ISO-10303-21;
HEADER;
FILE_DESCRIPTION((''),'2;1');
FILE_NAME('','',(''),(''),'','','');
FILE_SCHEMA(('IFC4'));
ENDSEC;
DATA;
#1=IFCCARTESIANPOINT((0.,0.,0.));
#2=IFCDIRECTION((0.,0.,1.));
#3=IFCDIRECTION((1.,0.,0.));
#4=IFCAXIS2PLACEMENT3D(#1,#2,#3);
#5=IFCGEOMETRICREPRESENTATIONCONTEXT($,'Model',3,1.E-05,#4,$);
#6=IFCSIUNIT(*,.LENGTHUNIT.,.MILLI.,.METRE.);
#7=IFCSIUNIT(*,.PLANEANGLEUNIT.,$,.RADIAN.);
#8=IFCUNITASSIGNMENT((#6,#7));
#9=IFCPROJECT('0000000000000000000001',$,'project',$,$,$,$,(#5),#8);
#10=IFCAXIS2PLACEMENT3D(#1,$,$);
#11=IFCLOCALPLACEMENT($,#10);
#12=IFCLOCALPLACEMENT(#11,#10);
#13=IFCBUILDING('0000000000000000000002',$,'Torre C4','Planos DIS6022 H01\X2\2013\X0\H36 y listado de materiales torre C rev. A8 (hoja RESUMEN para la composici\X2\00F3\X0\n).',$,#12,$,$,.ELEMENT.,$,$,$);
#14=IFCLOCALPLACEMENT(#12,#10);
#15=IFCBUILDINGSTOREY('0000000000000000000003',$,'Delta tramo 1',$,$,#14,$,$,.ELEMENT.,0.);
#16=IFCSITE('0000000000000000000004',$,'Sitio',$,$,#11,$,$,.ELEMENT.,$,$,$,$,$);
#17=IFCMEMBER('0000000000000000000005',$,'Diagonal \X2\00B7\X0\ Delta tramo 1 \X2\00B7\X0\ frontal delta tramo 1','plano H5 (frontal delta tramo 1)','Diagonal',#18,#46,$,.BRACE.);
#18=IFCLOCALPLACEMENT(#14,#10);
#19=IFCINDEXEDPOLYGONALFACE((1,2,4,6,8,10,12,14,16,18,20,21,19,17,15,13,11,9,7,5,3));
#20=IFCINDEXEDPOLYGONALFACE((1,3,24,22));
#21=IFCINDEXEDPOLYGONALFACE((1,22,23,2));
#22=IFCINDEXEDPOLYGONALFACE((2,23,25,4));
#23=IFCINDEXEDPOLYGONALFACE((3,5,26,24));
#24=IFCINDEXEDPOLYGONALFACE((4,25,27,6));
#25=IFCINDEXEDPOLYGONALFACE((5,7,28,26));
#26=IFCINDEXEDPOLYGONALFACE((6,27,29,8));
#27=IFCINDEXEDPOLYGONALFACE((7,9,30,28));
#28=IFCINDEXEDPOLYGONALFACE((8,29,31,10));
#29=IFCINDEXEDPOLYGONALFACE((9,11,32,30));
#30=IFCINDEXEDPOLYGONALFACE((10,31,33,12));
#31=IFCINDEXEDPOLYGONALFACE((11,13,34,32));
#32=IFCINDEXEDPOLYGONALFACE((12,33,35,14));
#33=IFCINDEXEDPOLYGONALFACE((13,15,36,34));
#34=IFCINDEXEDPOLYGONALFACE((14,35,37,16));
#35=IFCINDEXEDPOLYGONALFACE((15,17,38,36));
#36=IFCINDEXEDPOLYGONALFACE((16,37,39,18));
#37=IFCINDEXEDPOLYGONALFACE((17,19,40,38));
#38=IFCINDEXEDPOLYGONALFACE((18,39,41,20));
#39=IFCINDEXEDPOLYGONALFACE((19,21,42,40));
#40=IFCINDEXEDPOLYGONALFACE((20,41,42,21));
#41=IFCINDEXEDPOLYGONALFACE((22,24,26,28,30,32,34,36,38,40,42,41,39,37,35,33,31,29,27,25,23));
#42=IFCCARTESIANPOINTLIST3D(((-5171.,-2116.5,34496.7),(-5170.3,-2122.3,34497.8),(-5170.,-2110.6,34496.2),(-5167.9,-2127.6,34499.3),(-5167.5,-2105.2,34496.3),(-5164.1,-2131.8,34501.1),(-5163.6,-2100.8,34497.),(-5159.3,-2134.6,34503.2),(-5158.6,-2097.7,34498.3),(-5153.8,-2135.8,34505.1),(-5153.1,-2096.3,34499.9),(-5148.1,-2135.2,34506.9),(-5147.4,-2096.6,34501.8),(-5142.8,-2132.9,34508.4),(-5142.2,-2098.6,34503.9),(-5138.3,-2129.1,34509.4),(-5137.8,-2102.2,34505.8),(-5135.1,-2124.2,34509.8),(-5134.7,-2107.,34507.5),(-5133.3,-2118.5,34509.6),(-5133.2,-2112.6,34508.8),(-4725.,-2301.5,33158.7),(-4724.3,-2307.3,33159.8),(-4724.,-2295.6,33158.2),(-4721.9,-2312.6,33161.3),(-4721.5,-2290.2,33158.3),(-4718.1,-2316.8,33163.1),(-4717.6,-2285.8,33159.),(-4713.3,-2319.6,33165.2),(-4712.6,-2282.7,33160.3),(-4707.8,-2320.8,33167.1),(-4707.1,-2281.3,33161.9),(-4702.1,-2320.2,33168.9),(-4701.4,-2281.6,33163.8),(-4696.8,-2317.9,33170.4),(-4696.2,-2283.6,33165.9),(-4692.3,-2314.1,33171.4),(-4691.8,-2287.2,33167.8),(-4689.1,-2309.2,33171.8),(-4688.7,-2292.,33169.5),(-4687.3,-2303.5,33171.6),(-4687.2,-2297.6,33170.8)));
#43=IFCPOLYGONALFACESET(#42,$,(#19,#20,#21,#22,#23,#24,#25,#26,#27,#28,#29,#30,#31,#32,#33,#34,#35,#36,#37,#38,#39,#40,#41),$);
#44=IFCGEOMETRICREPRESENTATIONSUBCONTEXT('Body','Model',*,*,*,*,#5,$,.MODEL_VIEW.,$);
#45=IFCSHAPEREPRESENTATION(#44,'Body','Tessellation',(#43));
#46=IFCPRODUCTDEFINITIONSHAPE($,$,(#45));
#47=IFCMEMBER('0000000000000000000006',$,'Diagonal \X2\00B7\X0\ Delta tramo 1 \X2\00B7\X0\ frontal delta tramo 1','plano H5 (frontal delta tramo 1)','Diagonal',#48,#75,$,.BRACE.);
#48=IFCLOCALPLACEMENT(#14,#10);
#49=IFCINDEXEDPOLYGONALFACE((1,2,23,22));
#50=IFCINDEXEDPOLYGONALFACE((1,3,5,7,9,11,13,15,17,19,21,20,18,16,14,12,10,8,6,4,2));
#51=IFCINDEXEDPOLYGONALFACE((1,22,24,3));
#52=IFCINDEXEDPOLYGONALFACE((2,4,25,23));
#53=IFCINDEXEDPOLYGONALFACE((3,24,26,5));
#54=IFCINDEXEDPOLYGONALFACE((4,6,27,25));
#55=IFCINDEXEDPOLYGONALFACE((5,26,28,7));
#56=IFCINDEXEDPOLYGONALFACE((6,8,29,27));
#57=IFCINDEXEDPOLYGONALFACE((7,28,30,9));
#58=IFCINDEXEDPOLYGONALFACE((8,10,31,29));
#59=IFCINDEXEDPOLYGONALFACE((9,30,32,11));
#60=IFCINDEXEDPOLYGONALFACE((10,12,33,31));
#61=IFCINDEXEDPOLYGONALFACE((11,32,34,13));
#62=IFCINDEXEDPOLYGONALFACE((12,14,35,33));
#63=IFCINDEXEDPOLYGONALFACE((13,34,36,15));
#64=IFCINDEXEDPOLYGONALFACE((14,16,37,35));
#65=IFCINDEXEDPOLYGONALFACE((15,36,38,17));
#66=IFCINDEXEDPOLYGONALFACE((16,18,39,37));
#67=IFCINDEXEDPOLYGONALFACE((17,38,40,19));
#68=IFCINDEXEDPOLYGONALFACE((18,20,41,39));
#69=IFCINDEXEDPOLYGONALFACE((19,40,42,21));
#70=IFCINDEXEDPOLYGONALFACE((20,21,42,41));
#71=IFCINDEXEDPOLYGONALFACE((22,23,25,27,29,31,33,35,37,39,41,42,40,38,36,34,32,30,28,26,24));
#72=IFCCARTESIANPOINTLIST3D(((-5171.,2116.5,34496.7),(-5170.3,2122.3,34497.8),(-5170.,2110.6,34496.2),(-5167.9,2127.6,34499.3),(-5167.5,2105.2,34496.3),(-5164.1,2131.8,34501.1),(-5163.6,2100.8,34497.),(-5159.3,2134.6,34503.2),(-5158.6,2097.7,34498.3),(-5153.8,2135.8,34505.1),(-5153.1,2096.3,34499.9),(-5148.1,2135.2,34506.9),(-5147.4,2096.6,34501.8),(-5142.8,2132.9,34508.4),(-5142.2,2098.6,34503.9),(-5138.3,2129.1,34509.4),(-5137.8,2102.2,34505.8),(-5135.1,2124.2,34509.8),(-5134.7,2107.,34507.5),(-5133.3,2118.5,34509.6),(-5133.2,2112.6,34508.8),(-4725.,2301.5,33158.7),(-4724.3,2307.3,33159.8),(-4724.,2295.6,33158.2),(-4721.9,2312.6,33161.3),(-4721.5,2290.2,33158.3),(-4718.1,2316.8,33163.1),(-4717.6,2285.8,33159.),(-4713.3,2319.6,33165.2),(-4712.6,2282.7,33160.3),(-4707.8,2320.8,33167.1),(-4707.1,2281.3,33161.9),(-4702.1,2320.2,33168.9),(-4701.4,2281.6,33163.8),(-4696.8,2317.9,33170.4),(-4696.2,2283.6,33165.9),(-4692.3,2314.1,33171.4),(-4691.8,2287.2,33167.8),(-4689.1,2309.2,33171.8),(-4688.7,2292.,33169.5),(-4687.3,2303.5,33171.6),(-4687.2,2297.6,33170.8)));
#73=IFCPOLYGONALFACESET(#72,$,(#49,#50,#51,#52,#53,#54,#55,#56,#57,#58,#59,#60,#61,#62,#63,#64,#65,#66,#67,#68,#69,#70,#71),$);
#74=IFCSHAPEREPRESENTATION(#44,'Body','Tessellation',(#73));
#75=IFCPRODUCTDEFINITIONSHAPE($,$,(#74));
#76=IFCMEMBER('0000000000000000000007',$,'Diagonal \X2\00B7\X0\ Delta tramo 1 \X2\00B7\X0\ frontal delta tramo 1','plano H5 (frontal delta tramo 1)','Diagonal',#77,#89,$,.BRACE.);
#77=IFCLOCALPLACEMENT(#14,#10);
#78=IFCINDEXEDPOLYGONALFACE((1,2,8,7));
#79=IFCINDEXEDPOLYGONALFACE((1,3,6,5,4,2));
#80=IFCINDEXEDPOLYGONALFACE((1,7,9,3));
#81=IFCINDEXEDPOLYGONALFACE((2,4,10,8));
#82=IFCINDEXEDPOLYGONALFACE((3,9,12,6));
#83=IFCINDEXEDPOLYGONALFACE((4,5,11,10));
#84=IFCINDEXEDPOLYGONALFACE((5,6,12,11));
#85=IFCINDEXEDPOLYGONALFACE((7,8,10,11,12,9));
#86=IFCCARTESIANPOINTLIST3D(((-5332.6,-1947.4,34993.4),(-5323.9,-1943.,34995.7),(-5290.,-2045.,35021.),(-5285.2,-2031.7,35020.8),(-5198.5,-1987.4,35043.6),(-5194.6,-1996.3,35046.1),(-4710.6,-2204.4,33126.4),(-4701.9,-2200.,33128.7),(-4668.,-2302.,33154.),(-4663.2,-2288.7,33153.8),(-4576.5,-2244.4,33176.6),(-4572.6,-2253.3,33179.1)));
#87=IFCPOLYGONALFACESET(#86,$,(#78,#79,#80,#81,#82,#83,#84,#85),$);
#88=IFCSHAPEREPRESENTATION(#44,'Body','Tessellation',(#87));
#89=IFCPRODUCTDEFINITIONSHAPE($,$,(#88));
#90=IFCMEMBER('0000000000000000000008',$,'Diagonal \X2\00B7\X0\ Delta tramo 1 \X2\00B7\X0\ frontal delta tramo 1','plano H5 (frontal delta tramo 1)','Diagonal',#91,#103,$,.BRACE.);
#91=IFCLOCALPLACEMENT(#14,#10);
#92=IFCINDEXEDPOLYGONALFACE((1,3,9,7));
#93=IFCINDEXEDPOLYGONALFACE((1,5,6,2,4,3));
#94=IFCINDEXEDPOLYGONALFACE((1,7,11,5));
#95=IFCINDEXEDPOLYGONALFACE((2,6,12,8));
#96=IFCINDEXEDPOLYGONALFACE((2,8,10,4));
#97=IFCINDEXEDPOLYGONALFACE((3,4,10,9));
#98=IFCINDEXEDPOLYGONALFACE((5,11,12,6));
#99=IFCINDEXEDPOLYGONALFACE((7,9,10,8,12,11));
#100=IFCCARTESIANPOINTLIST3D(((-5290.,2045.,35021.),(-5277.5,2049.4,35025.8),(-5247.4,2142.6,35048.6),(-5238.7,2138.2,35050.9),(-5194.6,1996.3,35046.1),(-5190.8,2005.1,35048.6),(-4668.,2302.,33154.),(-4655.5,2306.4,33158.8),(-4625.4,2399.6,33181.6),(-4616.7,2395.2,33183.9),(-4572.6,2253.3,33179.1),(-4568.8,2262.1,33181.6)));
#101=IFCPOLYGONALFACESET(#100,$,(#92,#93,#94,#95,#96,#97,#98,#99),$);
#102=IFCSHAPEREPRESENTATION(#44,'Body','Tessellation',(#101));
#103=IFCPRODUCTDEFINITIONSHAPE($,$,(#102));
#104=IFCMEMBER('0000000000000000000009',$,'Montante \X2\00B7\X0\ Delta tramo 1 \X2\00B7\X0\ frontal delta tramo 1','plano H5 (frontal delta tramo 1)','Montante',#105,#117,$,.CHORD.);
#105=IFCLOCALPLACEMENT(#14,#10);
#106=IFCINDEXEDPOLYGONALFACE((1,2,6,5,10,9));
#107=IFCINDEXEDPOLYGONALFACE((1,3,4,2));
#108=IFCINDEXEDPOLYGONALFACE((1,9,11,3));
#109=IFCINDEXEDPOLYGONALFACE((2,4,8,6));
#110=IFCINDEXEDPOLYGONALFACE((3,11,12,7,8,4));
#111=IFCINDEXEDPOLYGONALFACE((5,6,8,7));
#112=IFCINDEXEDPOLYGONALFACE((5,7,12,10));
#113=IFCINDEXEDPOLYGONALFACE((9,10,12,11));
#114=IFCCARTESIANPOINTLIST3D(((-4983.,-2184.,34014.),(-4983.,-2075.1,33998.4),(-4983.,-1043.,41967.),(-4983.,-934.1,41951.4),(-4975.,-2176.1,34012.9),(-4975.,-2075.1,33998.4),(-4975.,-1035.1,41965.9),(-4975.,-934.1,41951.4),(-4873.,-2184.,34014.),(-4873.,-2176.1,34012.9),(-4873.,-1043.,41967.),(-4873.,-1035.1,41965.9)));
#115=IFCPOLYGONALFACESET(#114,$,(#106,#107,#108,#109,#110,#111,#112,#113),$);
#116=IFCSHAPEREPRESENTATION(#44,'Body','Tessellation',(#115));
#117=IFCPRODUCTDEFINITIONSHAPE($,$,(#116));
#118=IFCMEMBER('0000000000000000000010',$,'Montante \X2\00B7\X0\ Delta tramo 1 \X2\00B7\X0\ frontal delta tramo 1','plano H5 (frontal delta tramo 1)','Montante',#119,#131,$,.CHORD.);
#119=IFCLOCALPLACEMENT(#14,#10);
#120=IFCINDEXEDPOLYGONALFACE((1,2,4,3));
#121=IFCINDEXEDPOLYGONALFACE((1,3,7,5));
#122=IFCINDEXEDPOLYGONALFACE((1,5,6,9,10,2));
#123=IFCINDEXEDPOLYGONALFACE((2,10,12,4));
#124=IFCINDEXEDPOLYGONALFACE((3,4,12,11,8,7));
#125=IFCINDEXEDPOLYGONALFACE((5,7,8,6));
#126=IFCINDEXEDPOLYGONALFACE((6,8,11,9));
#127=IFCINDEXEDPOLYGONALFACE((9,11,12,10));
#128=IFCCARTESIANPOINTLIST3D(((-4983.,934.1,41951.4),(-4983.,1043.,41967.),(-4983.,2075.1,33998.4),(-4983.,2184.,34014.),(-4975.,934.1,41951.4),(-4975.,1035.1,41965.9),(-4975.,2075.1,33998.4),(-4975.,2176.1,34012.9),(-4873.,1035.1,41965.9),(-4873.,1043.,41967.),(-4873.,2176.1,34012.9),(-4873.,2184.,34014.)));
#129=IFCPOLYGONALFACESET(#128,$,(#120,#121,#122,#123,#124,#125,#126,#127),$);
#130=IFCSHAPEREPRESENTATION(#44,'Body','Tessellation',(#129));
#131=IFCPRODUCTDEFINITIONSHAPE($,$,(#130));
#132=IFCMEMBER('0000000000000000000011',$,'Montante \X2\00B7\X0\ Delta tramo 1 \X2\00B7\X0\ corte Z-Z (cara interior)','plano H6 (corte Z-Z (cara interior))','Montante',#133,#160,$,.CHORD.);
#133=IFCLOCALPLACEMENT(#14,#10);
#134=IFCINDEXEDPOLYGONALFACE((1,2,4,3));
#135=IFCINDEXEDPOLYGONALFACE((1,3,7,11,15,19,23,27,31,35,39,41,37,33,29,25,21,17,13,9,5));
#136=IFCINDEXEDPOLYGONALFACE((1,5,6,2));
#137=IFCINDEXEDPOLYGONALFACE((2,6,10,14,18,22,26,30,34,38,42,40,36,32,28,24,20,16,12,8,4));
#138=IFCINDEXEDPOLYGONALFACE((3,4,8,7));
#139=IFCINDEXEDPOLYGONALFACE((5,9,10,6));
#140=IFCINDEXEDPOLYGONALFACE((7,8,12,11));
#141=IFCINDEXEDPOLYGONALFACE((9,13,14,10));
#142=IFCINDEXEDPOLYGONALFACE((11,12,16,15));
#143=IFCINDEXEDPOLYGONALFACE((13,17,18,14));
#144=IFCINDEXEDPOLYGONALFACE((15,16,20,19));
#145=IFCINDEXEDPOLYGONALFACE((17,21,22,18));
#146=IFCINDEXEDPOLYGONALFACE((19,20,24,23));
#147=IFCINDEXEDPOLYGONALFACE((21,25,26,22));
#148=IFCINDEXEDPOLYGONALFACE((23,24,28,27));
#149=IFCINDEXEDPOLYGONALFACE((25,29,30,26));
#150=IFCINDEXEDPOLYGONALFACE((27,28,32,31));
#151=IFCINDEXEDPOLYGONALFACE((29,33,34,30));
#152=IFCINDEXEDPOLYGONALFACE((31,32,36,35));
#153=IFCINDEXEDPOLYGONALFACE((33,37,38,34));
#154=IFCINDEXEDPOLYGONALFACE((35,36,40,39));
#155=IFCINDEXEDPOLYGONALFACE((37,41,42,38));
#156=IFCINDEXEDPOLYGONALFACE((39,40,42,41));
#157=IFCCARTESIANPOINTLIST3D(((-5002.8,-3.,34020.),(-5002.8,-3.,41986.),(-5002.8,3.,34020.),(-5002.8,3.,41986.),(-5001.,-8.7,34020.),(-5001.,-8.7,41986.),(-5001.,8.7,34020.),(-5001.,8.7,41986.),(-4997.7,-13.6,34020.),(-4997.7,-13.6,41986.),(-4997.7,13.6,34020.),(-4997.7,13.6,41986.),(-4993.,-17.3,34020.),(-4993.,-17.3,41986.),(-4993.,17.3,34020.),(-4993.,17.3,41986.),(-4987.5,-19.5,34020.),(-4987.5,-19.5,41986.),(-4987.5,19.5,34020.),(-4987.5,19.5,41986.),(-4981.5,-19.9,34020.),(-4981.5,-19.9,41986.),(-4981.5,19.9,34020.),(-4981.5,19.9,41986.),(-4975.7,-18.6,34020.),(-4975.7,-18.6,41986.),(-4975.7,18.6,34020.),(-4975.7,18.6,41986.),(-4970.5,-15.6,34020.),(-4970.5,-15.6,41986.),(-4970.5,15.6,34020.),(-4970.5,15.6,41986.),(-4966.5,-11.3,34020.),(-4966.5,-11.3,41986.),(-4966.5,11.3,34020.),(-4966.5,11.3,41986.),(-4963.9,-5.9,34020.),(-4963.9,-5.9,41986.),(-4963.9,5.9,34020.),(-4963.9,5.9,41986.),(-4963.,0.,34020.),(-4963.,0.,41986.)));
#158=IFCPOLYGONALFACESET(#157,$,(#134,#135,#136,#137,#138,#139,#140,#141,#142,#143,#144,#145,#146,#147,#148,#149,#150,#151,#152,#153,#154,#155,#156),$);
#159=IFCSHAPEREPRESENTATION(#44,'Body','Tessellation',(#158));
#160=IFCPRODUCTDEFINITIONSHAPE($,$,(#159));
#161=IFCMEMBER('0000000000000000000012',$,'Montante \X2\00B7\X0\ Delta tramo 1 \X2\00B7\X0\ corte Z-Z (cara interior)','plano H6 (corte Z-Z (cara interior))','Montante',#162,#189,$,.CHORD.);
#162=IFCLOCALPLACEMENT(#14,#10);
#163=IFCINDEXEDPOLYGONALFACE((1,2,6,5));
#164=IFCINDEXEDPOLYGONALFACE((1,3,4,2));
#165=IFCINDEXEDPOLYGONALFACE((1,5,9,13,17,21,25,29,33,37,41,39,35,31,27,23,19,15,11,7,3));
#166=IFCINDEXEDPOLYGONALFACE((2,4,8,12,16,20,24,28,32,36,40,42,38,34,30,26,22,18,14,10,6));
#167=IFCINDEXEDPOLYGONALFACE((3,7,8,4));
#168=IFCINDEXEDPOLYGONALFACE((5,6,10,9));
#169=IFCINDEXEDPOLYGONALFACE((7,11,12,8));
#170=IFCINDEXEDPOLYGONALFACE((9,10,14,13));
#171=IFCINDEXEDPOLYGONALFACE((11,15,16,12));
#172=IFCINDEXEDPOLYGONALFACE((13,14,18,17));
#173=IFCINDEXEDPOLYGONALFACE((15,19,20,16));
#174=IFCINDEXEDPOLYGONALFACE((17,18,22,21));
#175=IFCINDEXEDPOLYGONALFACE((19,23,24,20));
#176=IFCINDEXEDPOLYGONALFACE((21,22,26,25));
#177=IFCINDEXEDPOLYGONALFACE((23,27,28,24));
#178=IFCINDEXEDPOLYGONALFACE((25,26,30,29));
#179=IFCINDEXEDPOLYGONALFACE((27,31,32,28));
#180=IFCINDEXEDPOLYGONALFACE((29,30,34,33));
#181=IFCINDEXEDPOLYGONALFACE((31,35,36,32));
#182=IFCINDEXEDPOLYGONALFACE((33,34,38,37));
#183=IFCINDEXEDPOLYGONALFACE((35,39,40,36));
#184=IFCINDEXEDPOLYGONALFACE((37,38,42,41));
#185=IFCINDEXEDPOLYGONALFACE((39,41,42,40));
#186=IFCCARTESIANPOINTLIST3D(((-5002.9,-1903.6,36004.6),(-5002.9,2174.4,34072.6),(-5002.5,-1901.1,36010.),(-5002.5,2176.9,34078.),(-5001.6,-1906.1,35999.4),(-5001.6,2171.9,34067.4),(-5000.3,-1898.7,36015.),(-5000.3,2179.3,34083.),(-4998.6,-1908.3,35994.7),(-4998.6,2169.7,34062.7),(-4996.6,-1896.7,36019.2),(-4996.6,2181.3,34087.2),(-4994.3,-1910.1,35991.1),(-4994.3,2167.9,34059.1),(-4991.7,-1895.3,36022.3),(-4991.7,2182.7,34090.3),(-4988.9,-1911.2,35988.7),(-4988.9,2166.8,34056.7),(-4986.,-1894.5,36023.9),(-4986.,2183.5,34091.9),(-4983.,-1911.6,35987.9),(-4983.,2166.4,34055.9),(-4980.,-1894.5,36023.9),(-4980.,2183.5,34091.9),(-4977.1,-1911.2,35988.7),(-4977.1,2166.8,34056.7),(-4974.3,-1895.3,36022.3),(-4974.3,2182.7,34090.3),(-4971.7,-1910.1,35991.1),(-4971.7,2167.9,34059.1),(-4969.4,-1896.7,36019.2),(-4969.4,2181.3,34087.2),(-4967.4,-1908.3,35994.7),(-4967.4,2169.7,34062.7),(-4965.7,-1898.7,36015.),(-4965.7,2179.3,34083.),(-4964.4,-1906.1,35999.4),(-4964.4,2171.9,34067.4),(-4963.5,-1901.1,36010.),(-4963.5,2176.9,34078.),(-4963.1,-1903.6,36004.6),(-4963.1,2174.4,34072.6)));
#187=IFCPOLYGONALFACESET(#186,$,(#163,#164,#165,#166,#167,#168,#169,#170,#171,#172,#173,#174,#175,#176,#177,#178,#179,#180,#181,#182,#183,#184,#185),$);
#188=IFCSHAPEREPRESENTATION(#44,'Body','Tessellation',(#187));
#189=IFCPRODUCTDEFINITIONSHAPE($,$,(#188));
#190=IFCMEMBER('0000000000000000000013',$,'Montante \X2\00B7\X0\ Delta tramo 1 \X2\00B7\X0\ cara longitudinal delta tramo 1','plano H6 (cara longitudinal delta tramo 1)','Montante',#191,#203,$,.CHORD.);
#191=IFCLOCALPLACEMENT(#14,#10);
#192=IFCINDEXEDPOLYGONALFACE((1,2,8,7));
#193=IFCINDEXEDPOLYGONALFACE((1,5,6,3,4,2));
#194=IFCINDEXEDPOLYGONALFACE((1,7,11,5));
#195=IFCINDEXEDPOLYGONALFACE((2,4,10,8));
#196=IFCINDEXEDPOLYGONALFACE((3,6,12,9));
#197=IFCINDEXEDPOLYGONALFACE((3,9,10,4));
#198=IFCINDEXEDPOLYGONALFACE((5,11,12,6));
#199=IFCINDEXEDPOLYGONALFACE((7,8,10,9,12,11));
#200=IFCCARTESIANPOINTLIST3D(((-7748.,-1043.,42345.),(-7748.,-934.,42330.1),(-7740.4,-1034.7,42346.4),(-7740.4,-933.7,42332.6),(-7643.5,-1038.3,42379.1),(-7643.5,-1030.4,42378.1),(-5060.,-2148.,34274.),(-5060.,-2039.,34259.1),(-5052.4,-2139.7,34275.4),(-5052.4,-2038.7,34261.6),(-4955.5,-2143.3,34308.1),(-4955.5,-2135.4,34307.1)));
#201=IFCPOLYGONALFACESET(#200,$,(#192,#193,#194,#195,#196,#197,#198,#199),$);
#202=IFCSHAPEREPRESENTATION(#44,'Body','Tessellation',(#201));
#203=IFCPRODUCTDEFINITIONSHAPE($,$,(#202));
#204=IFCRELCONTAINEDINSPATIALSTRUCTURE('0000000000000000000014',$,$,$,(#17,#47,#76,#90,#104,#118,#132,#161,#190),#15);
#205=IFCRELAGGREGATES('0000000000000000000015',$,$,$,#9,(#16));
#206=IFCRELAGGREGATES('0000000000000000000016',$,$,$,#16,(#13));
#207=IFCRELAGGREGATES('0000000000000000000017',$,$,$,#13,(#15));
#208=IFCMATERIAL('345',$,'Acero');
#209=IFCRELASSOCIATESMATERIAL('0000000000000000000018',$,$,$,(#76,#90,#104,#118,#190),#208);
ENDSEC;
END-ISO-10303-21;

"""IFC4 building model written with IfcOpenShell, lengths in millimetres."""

from ifc_helpers import new_model, si_unit, frame, frame_2d, origin, origin_with_axes, place, context, subcontext, project, spatial, circle, l_section, extrude, material, element, save


model = new_model("IFC4")

# Units and contexts
model_context = context("Model", 3, precision=1e-05, world=origin_with_axes())
body_context = subcontext(model_context, "Body", "Model", "MODEL_VIEW")
ifc_project = project(units=[si_unit("LENGTHUNIT", "METRE", prefix="MILLI"), si_unit("PLANEANGLEUNIT", "RADIAN")], contexts=[model_context])

# Site, building, storey
site_placement = place(None, origin())
site = spatial("IfcSite", under=ifc_project, at=site_placement, Name="Sitio", CompositionType="ELEMENT")
building_placement = place(site_placement, origin())
building = spatial("IfcBuilding", under=site, at=building_placement, Name="Torre C4", Description="Planos DIS6022 H01–H36 y listado de materiales torre C rev. A8 (hoja RESUMEN para la composición).", CompositionType="ELEMENT")
storey_placement = place(building_placement, origin())
storey = spatial("IfcBuildingStorey", under=building, at=storey_placement, Name="Delta tramo 1", CompositionType="ELEMENT", Elevation=0.0)

# Members
for number, where, z_axis, x_axis, name in (
    (1, (-4706.0, -2301.0, 33165.0), (-0.313542, 0.130057, 0.940626), (0.863292, 0.451616, 0.225321), "Diagonal · Delta tramo 1 · frontal delta tramo 1"),
    (2, (-4706.0, 2301.0, 33165.0), (-0.313542, -0.130057, 0.940626), (0.863292, -0.451616, 0.225321), "Diagonal · Delta tramo 1 · frontal delta tramo 1"),
):
    element("IfcMember", number, at=place(storey_placement, frame(where, z_axis=z_axis, x_axis=x_axis)), inside=storey, Name=name, Description="plano H5 (frontal delta tramo 1)", ObjectType="Diagonal", PredefinedType="BRACE", context=body_context, shape_type="SweptSolid", body=[
        extrude(circle(Radius=20.0), None, (0.0, 0.0, 1.0), 1422.5),
    ])
ifc_material_1 = material(Name="345", Category="Acero")
for number, where, z_axis, x_axis, name in (
    (3, (-4668.0, -2302.0, 33154.0), (-0.313414, 0.129497, 0.940746), (0.867067, 0.443015, 0.227885), "Diagonal · Delta tramo 1 · frontal delta tramo 1"),
    (4, (-4668.0, 2302.0, 33154.0), (-0.313414, -0.129497, 0.940746), (0.867067, -0.443015, 0.227885), "Diagonal · Delta tramo 1 · frontal delta tramo 1"),
):
    element("IfcMember", number, at=place(storey_placement, frame(where, z_axis=z_axis, x_axis=x_axis)), inside=storey, material=ifc_material_1, Name=name, Description="plano H5 (frontal delta tramo 1)", ObjectType="Diagonal", PredefinedType="BRACE", context=body_context, shape_type="SweptSolid", body=[
        extrude(l_section(Depth=110.0, Width=110.0, Thickness=10.0, at=frame_2d((55.0, 55.0))), None, (0.0, 0.0, 1.0), 1984.6),
    ])
for number, where, z_axis, x_axis, name in (
    (5, (-4983.0, -2184.0, 34014.0), (0.0, 0.142014, 0.989865), (1.0, 0.0, 0.0), "Montante · Delta tramo 1 · frontal delta tramo 1"),
    (6, (-4983.0, 2184.0, 34014.0), (0.0, -0.142014, 0.989865), (0.0, -0.989865, -0.142014), "Montante · Delta tramo 1 · frontal delta tramo 1"),
):
    element("IfcMember", number, at=place(storey_placement, frame(where, z_axis=z_axis, x_axis=x_axis)), inside=storey, material=ifc_material_1, Name=name, Description="plano H5 (frontal delta tramo 1)", ObjectType="Montante", PredefinedType="CHORD", context=body_context, shape_type="SweptSolid", body=[
        extrude(l_section(Depth=110.0, Width=110.0, Thickness=8.0, at=frame_2d((55.0, 55.0))), None, (0.0, 0.0, 1.0), 8034.4),
    ])
member_1_placement = place(storey_placement, frame((-4983.0, 0.0, 34020.0), z_axis=(0.0, 0.0, 1.0), x_axis=(1.0, 0.0, 0.0)))
element("IfcMember", 7, at=member_1_placement, inside=storey, Name="Montante · Delta tramo 1 · corte Z-Z (cara interior)", Description="plano H6 (corte Z-Z (cara interior))", ObjectType="Montante", PredefinedType="CHORD", context=body_context, shape_type="SweptSolid", body=[
    extrude(circle(Radius=20.0), None, (0.0, 0.0, 1.0), 7966.0),
])
member_2_placement = place(storey_placement, frame((-4983.0, 2175.0, 34074.0), z_axis=(0.0, -0.903711, 0.428144), x_axis=(0.0, -0.428144, -0.903711)))
element("IfcMember", 8, at=member_2_placement, inside=storey, Name="Montante · Delta tramo 1 · corte Z-Z (cara interior)", Description="plano H6 (corte Z-Z (cara interior))", ObjectType="Montante", PredefinedType="CHORD", context=body_context, shape_type="SweptSolid", body=[
    extrude(circle(Radius=20.0), None, (0.0, 0.0, 1.0), 4512.5),
])
member_3_placement = place(storey_placement, frame((-5060.0, -2148.0, 34274.0), z_axis=(-0.313348, 0.128813, 0.940861), x_axis=(0.949638, 0.042504, 0.310452)))
element("IfcMember", 9, at=member_3_placement, inside=storey, material=ifc_material_1, Name="Montante · Delta tramo 1 · cara longitudinal delta tramo 1", Description="plano H6 (cara longitudinal delta tramo 1)", ObjectType="Montante", PredefinedType="CHORD", context=body_context, shape_type="SweptSolid", body=[
    extrude(l_section(Depth=110.0, Width=110.0, Thickness=8.0, at=frame_2d((55.0, 55.0))), None, (0.0, 0.0, 1.0), 8578.3),
])

save(model, "model.ifc")
